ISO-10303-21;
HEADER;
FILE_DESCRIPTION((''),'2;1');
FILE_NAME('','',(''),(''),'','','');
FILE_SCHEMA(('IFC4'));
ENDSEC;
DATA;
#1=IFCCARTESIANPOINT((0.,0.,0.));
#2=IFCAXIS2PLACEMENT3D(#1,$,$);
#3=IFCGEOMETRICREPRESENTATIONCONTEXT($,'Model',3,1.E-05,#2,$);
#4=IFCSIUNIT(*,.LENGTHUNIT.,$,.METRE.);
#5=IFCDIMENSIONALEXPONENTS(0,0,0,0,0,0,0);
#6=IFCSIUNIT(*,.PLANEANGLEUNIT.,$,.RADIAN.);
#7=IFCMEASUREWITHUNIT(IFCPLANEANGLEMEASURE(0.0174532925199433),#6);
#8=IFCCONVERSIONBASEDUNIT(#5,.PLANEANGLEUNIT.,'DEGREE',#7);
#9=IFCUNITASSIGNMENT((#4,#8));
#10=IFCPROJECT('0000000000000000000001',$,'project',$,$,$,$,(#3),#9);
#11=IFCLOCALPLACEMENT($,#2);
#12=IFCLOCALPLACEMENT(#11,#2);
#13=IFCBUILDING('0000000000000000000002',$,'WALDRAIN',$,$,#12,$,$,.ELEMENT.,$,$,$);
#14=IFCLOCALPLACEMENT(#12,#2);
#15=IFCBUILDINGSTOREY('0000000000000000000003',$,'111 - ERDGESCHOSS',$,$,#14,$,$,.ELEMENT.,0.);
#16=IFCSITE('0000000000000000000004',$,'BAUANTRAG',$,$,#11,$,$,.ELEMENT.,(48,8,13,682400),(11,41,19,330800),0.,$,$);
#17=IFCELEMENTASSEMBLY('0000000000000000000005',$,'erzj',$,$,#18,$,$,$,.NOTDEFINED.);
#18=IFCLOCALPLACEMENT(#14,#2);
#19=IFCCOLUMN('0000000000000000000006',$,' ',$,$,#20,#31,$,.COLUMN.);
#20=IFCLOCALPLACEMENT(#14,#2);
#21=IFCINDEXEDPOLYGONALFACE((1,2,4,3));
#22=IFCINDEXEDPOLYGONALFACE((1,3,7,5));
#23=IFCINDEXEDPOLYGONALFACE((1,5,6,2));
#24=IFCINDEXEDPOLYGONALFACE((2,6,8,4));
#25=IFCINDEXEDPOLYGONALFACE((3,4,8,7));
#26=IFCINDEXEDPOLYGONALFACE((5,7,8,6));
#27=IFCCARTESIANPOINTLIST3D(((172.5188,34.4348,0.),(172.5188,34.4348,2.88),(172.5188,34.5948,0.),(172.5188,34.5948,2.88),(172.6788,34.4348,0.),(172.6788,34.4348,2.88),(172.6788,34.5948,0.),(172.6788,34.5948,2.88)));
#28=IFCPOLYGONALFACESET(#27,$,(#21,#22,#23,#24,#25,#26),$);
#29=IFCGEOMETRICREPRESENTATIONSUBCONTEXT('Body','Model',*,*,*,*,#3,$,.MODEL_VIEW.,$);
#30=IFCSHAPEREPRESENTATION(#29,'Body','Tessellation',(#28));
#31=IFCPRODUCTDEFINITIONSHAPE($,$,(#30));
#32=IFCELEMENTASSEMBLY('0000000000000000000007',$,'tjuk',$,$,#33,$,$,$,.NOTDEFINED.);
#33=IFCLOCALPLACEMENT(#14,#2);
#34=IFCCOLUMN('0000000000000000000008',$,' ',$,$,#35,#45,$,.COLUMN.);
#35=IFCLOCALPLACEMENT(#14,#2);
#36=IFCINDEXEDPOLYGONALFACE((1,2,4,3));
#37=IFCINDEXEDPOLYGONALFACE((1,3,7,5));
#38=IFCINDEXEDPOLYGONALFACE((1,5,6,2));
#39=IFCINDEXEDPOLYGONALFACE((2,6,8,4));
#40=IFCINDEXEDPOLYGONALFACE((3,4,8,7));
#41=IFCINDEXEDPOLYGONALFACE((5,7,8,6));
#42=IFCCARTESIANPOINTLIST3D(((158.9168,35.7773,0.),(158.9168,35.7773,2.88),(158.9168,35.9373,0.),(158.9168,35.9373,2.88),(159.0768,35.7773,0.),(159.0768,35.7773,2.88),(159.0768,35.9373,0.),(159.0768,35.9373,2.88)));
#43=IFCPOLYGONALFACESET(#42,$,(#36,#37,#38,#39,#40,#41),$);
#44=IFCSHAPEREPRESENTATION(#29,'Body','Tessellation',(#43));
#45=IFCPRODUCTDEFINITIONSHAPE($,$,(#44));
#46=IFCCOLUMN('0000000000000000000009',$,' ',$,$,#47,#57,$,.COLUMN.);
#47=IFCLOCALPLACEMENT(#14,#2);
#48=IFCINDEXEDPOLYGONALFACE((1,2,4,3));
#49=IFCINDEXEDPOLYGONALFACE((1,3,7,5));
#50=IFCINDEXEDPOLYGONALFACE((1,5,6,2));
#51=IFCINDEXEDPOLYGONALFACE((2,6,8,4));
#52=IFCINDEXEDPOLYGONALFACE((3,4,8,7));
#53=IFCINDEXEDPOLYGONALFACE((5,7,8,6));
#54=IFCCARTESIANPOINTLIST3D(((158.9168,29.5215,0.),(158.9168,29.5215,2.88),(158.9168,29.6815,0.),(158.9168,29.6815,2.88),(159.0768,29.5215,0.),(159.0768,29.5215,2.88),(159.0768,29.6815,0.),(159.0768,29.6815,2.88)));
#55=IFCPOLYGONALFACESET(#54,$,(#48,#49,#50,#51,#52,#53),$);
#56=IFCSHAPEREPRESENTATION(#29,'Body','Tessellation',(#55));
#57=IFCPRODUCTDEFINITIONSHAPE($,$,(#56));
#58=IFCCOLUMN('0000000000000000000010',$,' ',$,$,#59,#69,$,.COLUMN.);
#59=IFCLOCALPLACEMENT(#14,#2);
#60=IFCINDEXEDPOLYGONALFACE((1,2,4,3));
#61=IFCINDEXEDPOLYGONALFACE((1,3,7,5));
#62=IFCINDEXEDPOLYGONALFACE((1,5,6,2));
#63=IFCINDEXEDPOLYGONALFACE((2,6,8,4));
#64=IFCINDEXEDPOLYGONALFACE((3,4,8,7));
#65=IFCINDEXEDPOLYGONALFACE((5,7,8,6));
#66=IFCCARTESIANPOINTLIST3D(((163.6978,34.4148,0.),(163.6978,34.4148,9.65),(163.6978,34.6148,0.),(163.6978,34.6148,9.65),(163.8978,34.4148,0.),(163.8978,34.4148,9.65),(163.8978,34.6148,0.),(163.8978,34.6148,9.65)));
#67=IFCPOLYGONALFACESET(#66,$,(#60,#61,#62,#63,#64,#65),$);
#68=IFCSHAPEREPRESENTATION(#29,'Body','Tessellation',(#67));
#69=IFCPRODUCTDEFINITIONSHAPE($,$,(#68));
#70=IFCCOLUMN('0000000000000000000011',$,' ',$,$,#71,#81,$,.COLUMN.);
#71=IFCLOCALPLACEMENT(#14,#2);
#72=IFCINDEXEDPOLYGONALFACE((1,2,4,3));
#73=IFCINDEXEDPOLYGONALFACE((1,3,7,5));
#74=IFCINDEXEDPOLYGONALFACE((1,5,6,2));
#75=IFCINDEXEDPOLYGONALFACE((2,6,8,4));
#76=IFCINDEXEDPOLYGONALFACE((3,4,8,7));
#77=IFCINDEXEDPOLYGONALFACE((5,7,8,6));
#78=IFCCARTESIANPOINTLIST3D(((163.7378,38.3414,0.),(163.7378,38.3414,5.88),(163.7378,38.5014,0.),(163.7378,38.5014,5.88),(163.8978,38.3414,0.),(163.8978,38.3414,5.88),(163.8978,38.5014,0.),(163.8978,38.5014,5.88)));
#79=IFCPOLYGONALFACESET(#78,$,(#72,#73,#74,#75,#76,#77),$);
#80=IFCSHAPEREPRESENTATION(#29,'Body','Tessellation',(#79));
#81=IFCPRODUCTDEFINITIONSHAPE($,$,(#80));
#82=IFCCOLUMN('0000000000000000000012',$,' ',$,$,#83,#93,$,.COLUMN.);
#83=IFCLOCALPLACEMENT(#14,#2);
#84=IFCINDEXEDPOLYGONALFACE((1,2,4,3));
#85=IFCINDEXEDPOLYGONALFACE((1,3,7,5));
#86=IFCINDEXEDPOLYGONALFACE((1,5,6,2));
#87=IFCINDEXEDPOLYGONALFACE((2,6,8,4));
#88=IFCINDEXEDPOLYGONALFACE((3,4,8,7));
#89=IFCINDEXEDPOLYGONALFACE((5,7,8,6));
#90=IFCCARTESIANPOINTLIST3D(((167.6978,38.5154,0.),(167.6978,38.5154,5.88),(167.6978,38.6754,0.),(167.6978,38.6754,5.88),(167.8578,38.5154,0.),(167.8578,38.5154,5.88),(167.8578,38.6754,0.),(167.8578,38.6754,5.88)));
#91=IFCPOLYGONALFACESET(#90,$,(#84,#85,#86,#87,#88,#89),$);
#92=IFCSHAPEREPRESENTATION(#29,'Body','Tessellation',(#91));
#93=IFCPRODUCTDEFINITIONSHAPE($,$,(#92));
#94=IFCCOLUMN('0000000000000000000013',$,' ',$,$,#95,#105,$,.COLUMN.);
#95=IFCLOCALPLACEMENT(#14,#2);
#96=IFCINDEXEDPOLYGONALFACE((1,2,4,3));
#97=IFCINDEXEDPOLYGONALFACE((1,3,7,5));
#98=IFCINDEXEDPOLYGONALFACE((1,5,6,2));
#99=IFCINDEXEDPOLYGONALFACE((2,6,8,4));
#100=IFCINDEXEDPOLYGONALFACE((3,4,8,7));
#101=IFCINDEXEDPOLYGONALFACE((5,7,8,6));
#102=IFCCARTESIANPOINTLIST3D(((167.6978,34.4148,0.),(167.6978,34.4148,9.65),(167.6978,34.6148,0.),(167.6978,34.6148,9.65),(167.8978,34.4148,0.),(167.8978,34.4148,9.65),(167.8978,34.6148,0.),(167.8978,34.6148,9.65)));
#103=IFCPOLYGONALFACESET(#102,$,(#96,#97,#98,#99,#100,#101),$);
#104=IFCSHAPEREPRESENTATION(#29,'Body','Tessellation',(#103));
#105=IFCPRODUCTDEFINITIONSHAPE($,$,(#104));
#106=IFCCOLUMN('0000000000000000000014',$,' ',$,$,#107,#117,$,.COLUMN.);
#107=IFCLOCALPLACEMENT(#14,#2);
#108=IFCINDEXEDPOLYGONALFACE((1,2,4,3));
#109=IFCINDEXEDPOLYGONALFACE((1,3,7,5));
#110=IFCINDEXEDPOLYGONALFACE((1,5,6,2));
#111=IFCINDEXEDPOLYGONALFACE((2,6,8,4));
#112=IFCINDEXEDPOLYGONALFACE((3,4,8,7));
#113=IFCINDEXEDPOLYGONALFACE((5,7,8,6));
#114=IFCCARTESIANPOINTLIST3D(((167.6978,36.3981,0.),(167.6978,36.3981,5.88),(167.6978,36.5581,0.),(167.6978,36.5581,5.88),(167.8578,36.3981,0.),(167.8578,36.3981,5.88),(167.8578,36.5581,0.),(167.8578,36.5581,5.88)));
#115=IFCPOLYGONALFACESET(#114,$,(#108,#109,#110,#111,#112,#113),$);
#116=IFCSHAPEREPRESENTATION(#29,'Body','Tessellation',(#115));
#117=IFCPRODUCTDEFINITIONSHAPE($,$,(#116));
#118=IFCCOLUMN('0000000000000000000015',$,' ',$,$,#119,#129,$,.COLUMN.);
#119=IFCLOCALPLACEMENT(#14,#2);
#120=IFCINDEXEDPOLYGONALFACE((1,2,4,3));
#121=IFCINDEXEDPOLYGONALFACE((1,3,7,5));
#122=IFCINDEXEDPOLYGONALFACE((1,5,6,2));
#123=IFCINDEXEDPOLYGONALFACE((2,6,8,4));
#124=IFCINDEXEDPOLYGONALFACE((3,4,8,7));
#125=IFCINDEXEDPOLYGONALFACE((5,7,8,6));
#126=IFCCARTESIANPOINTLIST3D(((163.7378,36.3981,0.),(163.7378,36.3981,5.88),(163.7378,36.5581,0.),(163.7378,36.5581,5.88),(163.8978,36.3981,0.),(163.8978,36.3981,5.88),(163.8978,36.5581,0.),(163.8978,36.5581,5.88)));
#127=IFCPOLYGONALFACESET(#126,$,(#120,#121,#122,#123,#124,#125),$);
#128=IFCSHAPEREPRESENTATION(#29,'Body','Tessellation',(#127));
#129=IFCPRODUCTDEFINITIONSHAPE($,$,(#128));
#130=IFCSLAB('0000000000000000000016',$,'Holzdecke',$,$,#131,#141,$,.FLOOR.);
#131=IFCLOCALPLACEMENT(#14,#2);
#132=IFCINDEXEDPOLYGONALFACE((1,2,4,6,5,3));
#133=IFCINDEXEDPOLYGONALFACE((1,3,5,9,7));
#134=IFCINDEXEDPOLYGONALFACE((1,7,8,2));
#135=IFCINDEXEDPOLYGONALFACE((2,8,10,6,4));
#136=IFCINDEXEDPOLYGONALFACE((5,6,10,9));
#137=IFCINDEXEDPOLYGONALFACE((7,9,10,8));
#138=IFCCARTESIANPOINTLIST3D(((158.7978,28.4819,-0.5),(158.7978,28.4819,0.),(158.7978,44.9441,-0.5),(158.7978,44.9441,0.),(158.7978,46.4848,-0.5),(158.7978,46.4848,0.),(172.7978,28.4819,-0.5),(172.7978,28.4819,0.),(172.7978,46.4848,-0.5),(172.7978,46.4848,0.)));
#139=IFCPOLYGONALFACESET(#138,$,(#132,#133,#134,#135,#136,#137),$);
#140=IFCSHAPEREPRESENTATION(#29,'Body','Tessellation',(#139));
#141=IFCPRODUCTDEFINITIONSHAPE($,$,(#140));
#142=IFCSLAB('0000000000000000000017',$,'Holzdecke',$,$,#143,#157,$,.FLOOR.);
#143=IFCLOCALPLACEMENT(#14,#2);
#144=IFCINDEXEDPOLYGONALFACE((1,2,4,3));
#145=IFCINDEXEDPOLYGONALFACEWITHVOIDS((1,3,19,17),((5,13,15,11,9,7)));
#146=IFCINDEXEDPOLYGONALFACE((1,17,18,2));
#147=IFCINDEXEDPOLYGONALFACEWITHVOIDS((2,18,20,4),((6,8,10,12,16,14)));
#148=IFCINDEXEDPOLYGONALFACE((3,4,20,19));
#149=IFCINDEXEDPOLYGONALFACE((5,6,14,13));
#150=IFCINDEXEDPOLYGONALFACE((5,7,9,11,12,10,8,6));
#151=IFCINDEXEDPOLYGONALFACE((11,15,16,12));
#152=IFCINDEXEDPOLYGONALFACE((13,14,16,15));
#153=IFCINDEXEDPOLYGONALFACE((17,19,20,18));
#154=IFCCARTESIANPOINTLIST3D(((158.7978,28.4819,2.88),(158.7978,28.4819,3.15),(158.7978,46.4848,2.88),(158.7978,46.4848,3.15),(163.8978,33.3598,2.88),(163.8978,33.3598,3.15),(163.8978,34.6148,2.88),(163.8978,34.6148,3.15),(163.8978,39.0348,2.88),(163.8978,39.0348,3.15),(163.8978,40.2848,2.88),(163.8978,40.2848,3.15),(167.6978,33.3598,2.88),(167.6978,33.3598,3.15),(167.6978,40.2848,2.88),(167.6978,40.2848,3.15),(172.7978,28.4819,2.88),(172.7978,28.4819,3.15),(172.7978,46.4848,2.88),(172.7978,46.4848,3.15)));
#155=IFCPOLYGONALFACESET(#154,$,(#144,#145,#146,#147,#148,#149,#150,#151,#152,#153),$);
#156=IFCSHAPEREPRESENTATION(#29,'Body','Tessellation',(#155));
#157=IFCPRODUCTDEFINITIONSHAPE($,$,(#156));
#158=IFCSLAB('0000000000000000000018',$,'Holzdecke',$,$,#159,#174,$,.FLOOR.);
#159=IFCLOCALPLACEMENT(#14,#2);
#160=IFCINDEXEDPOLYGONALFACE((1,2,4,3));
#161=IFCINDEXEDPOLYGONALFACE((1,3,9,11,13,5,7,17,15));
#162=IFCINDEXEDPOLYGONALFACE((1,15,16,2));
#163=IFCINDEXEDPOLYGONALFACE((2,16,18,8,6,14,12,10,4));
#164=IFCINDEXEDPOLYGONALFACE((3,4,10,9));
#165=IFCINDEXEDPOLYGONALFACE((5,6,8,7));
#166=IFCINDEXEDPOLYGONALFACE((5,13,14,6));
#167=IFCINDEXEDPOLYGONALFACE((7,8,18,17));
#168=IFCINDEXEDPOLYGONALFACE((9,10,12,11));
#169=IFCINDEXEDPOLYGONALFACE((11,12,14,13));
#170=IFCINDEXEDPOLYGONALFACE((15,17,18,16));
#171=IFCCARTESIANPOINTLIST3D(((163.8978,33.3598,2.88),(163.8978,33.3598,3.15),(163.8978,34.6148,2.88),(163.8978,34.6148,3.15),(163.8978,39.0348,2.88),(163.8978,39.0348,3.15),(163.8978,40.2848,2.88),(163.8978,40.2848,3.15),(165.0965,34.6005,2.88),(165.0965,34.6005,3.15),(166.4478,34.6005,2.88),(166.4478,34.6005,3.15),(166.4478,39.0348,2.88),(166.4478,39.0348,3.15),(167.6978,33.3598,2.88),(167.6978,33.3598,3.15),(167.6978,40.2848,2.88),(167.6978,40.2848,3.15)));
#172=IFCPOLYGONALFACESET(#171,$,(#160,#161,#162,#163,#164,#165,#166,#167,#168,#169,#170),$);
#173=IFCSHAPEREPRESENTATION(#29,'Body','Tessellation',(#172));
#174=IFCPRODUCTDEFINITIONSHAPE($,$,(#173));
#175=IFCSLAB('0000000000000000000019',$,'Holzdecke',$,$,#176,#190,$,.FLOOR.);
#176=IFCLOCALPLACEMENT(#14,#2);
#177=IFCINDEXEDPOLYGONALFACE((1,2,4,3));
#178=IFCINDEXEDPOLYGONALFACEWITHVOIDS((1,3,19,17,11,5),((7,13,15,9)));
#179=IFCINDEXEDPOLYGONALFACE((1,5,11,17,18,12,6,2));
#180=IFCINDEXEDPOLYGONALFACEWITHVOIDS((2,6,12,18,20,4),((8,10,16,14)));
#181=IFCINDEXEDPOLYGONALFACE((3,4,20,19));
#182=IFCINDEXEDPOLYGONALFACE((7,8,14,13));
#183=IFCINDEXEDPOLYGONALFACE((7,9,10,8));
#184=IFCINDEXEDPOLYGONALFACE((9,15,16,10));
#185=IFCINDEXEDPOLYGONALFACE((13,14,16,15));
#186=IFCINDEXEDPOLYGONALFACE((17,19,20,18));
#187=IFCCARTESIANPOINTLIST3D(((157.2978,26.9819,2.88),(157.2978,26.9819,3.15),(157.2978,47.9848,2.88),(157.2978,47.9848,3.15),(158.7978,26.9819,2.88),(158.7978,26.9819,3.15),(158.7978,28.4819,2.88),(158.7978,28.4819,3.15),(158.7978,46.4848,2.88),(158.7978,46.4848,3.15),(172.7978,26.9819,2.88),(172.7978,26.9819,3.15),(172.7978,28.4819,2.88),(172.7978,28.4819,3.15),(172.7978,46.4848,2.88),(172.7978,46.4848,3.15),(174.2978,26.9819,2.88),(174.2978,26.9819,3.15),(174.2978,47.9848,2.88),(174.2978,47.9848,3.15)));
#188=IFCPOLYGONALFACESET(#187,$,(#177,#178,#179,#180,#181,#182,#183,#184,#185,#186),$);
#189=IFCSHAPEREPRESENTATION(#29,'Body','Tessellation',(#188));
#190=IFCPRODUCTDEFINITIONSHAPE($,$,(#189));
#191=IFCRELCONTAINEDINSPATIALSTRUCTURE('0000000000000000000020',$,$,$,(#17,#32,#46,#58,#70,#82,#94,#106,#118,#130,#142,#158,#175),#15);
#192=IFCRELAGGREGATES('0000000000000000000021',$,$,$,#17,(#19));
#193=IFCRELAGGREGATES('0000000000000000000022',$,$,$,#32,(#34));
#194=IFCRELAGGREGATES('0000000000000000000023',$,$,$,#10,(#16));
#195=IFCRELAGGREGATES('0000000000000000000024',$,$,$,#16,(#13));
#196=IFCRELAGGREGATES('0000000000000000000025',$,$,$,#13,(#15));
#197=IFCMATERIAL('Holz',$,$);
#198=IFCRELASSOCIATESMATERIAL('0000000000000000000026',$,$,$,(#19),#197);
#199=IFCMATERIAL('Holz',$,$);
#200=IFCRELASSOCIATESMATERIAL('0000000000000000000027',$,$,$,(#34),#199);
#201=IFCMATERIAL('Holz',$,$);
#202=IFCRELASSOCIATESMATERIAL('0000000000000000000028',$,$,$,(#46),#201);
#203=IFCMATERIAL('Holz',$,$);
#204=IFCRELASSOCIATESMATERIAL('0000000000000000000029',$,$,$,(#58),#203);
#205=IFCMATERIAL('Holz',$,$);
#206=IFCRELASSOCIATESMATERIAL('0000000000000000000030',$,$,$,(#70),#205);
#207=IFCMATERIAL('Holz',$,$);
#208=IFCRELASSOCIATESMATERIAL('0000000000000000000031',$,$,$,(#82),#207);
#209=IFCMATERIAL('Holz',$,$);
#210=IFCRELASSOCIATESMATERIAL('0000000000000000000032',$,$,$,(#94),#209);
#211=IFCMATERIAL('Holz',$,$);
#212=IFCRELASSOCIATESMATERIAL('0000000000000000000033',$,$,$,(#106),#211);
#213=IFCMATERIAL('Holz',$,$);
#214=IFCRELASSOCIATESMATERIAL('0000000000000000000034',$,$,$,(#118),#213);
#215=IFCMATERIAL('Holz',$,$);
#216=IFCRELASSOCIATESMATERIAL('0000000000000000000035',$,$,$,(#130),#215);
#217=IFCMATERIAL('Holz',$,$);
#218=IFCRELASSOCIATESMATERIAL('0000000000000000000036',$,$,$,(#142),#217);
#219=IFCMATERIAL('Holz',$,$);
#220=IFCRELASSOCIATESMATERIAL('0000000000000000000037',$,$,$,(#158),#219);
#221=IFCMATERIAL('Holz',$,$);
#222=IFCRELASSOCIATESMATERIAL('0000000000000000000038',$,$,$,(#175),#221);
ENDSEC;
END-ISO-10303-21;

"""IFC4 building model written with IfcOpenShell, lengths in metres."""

from ifc_helpers import new_model, entity, si_unit, converted_unit, frame, frame_2d, origin, origin_with_axes, place, context, subcontext, project, spatial, polyline, rectangle, outline, extrude, material, element, aggregate, save


model = new_model("IFC4")

# Units and contexts
model_context = context("Model", 3, precision=1e-05, world=origin())
body_context = subcontext(model_context, "Body", "Model", "MODEL_VIEW")
ifc_project = project(units=[si_unit("LENGTHUNIT", "METRE"), converted_unit("PLANEANGLEUNIT", "DEGREE", entity("IfcPlaneAngleMeasure", 0.0174532925199433), si_unit("PLANEANGLEUNIT", "RADIAN"), dimensions=[0, 0, 0, 0, 0, 0, 0])], contexts=[model_context])

# Site, building, storey
site_placement = place(None, origin())
site = spatial("IfcSite", under=ifc_project, at=site_placement, Name="BAUANTRAG", CompositionType="ELEMENT", RefLatitude=(48, 8, 13, 682400), RefLongitude=(11, 41, 19, 330800), RefElevation=0.0)
building_placement = place(site_placement, origin())
building = spatial("IfcBuilding", under=site, at=building_placement, Name="WALDRAIN", CompositionType="ELEMENT")
storey_placement = place(building_placement, origin())
storey = spatial("IfcBuildingStorey", under=building, at=storey_placement, Name="111 - ERDGESCHOSS", CompositionType="ELEMENT", Elevation=0.0)

# Element assemblies, columns
assembly_1_placement = place(storey_placement, origin())
assembly_1 = element("IfcElementAssembly", 1, at=assembly_1_placement, inside=storey, Name="erzj", PredefinedType="NOTDEFINED")
ifc_material_1 = material(Name="Holz")
column_1_placement = place(assembly_1_placement, frame((172.5188, 34.4348, 0.0)))
column_1 = element("IfcColumn", 2, at=column_1_placement, material=ifc_material_1, Name=" ", PredefinedType="COLUMN", context=body_context, shape_type="SweptSolid", body=[
    extrude(rectangle(XDim=0.16, YDim=0.16, at=frame_2d((0.08, 0.08), x_axis=(1.0, 0.0))), origin_with_axes(), (0.0, 0.0, 1.0), 2.88),
])
aggregate(assembly_1, [column_1])
assembly_2_placement = place(storey_placement, origin())
assembly_2 = element("IfcElementAssembly", 3, at=assembly_2_placement, inside=storey, Name="tjuk", PredefinedType="NOTDEFINED")
ifc_material_2 = material(Name="Holz")
column_2_placement = place(assembly_2_placement, frame((158.9168, 35.7773, 0.0)))
column_2 = element("IfcColumn", 4, at=column_2_placement, material=ifc_material_2, Name=" ", PredefinedType="COLUMN", context=body_context, shape_type="SweptSolid", body=[
    extrude(rectangle(XDim=0.16, YDim=0.16, at=frame_2d((0.08, 0.08), x_axis=(1.0, 0.0))), origin_with_axes(), (0.0, 0.0, 1.0), 2.88),
])
aggregate(assembly_2, [column_2])

# Columns
ifc_material_3 = material(Name="Holz")
column_3_placement = place(storey_placement, frame((158.9168, 29.5215, 0.0)))
element("IfcColumn", 5, at=column_3_placement, inside=storey, material=ifc_material_3, Name=" ", PredefinedType="COLUMN", context=body_context, shape_type="SweptSolid", body=[
    extrude(rectangle(XDim=0.16, YDim=0.16, at=frame_2d((0.08, 0.08), x_axis=(1.0, 0.0))), origin_with_axes(), (0.0, 0.0, 1.0), 2.88),
])
ifc_material_4 = material(Name="Holz")
column_4_placement = place(storey_placement, frame((163.6978, 34.4148, 0.0)))
element("IfcColumn", 6, at=column_4_placement, inside=storey, material=ifc_material_4, Name=" ", PredefinedType="COLUMN", context=body_context, shape_type="SweptSolid", body=[
    extrude(rectangle(XDim=0.2, YDim=0.2, at=frame_2d((0.1, 0.1), x_axis=(1.0, 0.0))), origin_with_axes(), (0.0, 0.0, 1.0), 9.65),
])
ifc_material_5 = material(Name="Holz")
column_5_placement = place(storey_placement, frame((163.7378, 38.3414, 0.0)))
element("IfcColumn", 7, at=column_5_placement, inside=storey, material=ifc_material_5, Name=" ", PredefinedType="COLUMN", context=body_context, shape_type="SweptSolid", body=[
    extrude(rectangle(XDim=0.16, YDim=0.16, at=frame_2d((0.08, 0.08), x_axis=(1.0, 0.0))), origin_with_axes(), (0.0, 0.0, 1.0), 5.88),
])
ifc_material_6 = material(Name="Holz")
column_6_placement = place(storey_placement, frame((167.6978, 38.5154, 0.0)))
element("IfcColumn", 8, at=column_6_placement, inside=storey, material=ifc_material_6, Name=" ", PredefinedType="COLUMN", context=body_context, shape_type="SweptSolid", body=[
    extrude(rectangle(XDim=0.16, YDim=0.16, at=frame_2d((0.08, 0.08), x_axis=(1.0, 0.0))), origin_with_axes(), (0.0, 0.0, 1.0), 5.88),
])
ifc_material_7 = material(Name="Holz")
column_7_placement = place(storey_placement, frame((167.6978, 34.4148, 0.0)))
element("IfcColumn", 9, at=column_7_placement, inside=storey, material=ifc_material_7, Name=" ", PredefinedType="COLUMN", context=body_context, shape_type="SweptSolid", body=[
    extrude(rectangle(XDim=0.2, YDim=0.2, at=frame_2d((0.1, 0.1), x_axis=(1.0, 0.0))), origin_with_axes(), (0.0, 0.0, 1.0), 9.65),
])
ifc_material_8 = material(Name="Holz")
column_8_placement = place(storey_placement, frame((167.6978, 36.3981, 0.0)))
element("IfcColumn", 10, at=column_8_placement, inside=storey, material=ifc_material_8, Name=" ", PredefinedType="COLUMN", context=body_context, shape_type="SweptSolid", body=[
    extrude(rectangle(XDim=0.16, YDim=0.16, at=frame_2d((0.08, 0.08), x_axis=(1.0, 0.0))), origin_with_axes(), (0.0, 0.0, 1.0), 5.88),
])
ifc_material_9 = material(Name="Holz")
column_9_placement = place(storey_placement, frame((163.7378, 36.3981, 0.0)))
element("IfcColumn", 11, at=column_9_placement, inside=storey, material=ifc_material_9, Name=" ", PredefinedType="COLUMN", context=body_context, shape_type="SweptSolid", body=[
    extrude(rectangle(XDim=0.16, YDim=0.16, at=frame_2d((0.08, 0.08), x_axis=(1.0, 0.0))), origin_with_axes(), (0.0, 0.0, 1.0), 5.88),
])

# Slab
ifc_material_10 = material(Name="Holz")
slab_1_placement = place(storey_placement, frame((158.7978, 28.4819, -0.5)))
element("IfcSlab", 12, at=slab_1_placement, inside=storey, material=ifc_material_10, Name="Holzdecke", PredefinedType="FLOOR", context=body_context, shape_type="SweptSolid", body=[
    extrude(outline(polyline([(0.0, 16.4622), (0.0, 0.0), (14.0, 0.0), (14.0, 18.0029), (0.0, 18.0029), (0.0, 16.4622)])), origin_with_axes(), (0.0, 0.0, 1.0), 0.5),
])

# Slab, opening
ifc_material_11 = material(Name="Holz")
slab_2_placement = place(storey_placement, frame((158.7978, 28.4819, 2.88)))
slab_2 = element("IfcSlab", 13, at=slab_2_placement, inside=storey, material=ifc_material_11, Name="Holzdecke", PredefinedType="FLOOR", context=body_context, shape_type="SweptSolid", body=[
    extrude(outline(polyline([(14.0, 0.0), (14.0, 18.0029), (0.0, 18.0029), (0.0, 0.0), (14.0, 0.0)]), holes=[polyline([(5.1, 10.5529), (5.1, 11.8029), (8.9, 11.8029), (8.9, 4.8779), (5.1, 4.8779), (5.1, 6.1329), (6.2988, 6.1186), (7.65, 6.1186), (7.65, 10.5529), (5.1, 10.5529)])]), origin_with_axes(), (0.0, 0.0, 1.0), 0.27),
])
opening_1_placement = place(slab_2_placement, frame((5.1, 4.8779, 0.0)))
element("IfcOpeningElement", 14, at=opening_1_placement, cuts=slab_2, ObjectType="Opening", context=body_context, shape_type="SweptSolid", body=[
    extrude(rectangle(XDim=3.8, YDim=6.925, at=frame_2d((0.0, 0.0), x_axis=(-1.0, 0.0))), frame((1.9, 3.4625, 0.0), z_axis=(0.0, 0.0, 1.0), x_axis=(1.0, 0.0, 0.0)), (0.0, 0.0, 1.0), 0.27),
])

# Slabs
ifc_material_12 = material(Name="Holz")
slab_3_placement = place(storey_placement, frame((163.8978, 33.3598, 2.88)))
element("IfcSlab", 15, at=slab_3_placement, inside=storey, material=ifc_material_12, Name="Holzdecke", PredefinedType="FLOOR", context=body_context, shape_type="SweptSolid", body=[
    extrude(outline(polyline([(0.0, 6.925), (0.0, 5.675), (2.55, 5.675), (2.55, 1.2408), (1.1988, 1.2408), (0.0, 1.255), (0.0, 0.0), (3.8, 0.0), (3.8, 6.925), (0.0, 6.925)])), origin_with_axes(), (0.0, 0.0, 1.0), 0.27),
])
ifc_material_13 = material(Name="Holz")
slab_4_placement = place(storey_placement, frame((157.2978, 26.9819, 2.88)))
element("IfcSlab", 16, at=slab_4_placement, inside=storey, material=ifc_material_13, Name="Holzdecke", PredefinedType="FLOOR", context=body_context, shape_type="SweptSolid", body=[
    extrude(outline(polyline([(17.0, 0.0), (17.0, 21.0029), (0.0, 21.0029), (0.0, 0.0), (1.5, 0.0), (15.5, 0.0), (17.0, 0.0)]), holes=[polyline([(15.5, 19.5029), (15.5, 1.5), (1.5, 1.5), (1.5, 19.5029), (15.5, 19.5029)])]), origin_with_axes(), (0.0, 0.0, 1.0), 0.27),
])

save(model, "model.ifc")
